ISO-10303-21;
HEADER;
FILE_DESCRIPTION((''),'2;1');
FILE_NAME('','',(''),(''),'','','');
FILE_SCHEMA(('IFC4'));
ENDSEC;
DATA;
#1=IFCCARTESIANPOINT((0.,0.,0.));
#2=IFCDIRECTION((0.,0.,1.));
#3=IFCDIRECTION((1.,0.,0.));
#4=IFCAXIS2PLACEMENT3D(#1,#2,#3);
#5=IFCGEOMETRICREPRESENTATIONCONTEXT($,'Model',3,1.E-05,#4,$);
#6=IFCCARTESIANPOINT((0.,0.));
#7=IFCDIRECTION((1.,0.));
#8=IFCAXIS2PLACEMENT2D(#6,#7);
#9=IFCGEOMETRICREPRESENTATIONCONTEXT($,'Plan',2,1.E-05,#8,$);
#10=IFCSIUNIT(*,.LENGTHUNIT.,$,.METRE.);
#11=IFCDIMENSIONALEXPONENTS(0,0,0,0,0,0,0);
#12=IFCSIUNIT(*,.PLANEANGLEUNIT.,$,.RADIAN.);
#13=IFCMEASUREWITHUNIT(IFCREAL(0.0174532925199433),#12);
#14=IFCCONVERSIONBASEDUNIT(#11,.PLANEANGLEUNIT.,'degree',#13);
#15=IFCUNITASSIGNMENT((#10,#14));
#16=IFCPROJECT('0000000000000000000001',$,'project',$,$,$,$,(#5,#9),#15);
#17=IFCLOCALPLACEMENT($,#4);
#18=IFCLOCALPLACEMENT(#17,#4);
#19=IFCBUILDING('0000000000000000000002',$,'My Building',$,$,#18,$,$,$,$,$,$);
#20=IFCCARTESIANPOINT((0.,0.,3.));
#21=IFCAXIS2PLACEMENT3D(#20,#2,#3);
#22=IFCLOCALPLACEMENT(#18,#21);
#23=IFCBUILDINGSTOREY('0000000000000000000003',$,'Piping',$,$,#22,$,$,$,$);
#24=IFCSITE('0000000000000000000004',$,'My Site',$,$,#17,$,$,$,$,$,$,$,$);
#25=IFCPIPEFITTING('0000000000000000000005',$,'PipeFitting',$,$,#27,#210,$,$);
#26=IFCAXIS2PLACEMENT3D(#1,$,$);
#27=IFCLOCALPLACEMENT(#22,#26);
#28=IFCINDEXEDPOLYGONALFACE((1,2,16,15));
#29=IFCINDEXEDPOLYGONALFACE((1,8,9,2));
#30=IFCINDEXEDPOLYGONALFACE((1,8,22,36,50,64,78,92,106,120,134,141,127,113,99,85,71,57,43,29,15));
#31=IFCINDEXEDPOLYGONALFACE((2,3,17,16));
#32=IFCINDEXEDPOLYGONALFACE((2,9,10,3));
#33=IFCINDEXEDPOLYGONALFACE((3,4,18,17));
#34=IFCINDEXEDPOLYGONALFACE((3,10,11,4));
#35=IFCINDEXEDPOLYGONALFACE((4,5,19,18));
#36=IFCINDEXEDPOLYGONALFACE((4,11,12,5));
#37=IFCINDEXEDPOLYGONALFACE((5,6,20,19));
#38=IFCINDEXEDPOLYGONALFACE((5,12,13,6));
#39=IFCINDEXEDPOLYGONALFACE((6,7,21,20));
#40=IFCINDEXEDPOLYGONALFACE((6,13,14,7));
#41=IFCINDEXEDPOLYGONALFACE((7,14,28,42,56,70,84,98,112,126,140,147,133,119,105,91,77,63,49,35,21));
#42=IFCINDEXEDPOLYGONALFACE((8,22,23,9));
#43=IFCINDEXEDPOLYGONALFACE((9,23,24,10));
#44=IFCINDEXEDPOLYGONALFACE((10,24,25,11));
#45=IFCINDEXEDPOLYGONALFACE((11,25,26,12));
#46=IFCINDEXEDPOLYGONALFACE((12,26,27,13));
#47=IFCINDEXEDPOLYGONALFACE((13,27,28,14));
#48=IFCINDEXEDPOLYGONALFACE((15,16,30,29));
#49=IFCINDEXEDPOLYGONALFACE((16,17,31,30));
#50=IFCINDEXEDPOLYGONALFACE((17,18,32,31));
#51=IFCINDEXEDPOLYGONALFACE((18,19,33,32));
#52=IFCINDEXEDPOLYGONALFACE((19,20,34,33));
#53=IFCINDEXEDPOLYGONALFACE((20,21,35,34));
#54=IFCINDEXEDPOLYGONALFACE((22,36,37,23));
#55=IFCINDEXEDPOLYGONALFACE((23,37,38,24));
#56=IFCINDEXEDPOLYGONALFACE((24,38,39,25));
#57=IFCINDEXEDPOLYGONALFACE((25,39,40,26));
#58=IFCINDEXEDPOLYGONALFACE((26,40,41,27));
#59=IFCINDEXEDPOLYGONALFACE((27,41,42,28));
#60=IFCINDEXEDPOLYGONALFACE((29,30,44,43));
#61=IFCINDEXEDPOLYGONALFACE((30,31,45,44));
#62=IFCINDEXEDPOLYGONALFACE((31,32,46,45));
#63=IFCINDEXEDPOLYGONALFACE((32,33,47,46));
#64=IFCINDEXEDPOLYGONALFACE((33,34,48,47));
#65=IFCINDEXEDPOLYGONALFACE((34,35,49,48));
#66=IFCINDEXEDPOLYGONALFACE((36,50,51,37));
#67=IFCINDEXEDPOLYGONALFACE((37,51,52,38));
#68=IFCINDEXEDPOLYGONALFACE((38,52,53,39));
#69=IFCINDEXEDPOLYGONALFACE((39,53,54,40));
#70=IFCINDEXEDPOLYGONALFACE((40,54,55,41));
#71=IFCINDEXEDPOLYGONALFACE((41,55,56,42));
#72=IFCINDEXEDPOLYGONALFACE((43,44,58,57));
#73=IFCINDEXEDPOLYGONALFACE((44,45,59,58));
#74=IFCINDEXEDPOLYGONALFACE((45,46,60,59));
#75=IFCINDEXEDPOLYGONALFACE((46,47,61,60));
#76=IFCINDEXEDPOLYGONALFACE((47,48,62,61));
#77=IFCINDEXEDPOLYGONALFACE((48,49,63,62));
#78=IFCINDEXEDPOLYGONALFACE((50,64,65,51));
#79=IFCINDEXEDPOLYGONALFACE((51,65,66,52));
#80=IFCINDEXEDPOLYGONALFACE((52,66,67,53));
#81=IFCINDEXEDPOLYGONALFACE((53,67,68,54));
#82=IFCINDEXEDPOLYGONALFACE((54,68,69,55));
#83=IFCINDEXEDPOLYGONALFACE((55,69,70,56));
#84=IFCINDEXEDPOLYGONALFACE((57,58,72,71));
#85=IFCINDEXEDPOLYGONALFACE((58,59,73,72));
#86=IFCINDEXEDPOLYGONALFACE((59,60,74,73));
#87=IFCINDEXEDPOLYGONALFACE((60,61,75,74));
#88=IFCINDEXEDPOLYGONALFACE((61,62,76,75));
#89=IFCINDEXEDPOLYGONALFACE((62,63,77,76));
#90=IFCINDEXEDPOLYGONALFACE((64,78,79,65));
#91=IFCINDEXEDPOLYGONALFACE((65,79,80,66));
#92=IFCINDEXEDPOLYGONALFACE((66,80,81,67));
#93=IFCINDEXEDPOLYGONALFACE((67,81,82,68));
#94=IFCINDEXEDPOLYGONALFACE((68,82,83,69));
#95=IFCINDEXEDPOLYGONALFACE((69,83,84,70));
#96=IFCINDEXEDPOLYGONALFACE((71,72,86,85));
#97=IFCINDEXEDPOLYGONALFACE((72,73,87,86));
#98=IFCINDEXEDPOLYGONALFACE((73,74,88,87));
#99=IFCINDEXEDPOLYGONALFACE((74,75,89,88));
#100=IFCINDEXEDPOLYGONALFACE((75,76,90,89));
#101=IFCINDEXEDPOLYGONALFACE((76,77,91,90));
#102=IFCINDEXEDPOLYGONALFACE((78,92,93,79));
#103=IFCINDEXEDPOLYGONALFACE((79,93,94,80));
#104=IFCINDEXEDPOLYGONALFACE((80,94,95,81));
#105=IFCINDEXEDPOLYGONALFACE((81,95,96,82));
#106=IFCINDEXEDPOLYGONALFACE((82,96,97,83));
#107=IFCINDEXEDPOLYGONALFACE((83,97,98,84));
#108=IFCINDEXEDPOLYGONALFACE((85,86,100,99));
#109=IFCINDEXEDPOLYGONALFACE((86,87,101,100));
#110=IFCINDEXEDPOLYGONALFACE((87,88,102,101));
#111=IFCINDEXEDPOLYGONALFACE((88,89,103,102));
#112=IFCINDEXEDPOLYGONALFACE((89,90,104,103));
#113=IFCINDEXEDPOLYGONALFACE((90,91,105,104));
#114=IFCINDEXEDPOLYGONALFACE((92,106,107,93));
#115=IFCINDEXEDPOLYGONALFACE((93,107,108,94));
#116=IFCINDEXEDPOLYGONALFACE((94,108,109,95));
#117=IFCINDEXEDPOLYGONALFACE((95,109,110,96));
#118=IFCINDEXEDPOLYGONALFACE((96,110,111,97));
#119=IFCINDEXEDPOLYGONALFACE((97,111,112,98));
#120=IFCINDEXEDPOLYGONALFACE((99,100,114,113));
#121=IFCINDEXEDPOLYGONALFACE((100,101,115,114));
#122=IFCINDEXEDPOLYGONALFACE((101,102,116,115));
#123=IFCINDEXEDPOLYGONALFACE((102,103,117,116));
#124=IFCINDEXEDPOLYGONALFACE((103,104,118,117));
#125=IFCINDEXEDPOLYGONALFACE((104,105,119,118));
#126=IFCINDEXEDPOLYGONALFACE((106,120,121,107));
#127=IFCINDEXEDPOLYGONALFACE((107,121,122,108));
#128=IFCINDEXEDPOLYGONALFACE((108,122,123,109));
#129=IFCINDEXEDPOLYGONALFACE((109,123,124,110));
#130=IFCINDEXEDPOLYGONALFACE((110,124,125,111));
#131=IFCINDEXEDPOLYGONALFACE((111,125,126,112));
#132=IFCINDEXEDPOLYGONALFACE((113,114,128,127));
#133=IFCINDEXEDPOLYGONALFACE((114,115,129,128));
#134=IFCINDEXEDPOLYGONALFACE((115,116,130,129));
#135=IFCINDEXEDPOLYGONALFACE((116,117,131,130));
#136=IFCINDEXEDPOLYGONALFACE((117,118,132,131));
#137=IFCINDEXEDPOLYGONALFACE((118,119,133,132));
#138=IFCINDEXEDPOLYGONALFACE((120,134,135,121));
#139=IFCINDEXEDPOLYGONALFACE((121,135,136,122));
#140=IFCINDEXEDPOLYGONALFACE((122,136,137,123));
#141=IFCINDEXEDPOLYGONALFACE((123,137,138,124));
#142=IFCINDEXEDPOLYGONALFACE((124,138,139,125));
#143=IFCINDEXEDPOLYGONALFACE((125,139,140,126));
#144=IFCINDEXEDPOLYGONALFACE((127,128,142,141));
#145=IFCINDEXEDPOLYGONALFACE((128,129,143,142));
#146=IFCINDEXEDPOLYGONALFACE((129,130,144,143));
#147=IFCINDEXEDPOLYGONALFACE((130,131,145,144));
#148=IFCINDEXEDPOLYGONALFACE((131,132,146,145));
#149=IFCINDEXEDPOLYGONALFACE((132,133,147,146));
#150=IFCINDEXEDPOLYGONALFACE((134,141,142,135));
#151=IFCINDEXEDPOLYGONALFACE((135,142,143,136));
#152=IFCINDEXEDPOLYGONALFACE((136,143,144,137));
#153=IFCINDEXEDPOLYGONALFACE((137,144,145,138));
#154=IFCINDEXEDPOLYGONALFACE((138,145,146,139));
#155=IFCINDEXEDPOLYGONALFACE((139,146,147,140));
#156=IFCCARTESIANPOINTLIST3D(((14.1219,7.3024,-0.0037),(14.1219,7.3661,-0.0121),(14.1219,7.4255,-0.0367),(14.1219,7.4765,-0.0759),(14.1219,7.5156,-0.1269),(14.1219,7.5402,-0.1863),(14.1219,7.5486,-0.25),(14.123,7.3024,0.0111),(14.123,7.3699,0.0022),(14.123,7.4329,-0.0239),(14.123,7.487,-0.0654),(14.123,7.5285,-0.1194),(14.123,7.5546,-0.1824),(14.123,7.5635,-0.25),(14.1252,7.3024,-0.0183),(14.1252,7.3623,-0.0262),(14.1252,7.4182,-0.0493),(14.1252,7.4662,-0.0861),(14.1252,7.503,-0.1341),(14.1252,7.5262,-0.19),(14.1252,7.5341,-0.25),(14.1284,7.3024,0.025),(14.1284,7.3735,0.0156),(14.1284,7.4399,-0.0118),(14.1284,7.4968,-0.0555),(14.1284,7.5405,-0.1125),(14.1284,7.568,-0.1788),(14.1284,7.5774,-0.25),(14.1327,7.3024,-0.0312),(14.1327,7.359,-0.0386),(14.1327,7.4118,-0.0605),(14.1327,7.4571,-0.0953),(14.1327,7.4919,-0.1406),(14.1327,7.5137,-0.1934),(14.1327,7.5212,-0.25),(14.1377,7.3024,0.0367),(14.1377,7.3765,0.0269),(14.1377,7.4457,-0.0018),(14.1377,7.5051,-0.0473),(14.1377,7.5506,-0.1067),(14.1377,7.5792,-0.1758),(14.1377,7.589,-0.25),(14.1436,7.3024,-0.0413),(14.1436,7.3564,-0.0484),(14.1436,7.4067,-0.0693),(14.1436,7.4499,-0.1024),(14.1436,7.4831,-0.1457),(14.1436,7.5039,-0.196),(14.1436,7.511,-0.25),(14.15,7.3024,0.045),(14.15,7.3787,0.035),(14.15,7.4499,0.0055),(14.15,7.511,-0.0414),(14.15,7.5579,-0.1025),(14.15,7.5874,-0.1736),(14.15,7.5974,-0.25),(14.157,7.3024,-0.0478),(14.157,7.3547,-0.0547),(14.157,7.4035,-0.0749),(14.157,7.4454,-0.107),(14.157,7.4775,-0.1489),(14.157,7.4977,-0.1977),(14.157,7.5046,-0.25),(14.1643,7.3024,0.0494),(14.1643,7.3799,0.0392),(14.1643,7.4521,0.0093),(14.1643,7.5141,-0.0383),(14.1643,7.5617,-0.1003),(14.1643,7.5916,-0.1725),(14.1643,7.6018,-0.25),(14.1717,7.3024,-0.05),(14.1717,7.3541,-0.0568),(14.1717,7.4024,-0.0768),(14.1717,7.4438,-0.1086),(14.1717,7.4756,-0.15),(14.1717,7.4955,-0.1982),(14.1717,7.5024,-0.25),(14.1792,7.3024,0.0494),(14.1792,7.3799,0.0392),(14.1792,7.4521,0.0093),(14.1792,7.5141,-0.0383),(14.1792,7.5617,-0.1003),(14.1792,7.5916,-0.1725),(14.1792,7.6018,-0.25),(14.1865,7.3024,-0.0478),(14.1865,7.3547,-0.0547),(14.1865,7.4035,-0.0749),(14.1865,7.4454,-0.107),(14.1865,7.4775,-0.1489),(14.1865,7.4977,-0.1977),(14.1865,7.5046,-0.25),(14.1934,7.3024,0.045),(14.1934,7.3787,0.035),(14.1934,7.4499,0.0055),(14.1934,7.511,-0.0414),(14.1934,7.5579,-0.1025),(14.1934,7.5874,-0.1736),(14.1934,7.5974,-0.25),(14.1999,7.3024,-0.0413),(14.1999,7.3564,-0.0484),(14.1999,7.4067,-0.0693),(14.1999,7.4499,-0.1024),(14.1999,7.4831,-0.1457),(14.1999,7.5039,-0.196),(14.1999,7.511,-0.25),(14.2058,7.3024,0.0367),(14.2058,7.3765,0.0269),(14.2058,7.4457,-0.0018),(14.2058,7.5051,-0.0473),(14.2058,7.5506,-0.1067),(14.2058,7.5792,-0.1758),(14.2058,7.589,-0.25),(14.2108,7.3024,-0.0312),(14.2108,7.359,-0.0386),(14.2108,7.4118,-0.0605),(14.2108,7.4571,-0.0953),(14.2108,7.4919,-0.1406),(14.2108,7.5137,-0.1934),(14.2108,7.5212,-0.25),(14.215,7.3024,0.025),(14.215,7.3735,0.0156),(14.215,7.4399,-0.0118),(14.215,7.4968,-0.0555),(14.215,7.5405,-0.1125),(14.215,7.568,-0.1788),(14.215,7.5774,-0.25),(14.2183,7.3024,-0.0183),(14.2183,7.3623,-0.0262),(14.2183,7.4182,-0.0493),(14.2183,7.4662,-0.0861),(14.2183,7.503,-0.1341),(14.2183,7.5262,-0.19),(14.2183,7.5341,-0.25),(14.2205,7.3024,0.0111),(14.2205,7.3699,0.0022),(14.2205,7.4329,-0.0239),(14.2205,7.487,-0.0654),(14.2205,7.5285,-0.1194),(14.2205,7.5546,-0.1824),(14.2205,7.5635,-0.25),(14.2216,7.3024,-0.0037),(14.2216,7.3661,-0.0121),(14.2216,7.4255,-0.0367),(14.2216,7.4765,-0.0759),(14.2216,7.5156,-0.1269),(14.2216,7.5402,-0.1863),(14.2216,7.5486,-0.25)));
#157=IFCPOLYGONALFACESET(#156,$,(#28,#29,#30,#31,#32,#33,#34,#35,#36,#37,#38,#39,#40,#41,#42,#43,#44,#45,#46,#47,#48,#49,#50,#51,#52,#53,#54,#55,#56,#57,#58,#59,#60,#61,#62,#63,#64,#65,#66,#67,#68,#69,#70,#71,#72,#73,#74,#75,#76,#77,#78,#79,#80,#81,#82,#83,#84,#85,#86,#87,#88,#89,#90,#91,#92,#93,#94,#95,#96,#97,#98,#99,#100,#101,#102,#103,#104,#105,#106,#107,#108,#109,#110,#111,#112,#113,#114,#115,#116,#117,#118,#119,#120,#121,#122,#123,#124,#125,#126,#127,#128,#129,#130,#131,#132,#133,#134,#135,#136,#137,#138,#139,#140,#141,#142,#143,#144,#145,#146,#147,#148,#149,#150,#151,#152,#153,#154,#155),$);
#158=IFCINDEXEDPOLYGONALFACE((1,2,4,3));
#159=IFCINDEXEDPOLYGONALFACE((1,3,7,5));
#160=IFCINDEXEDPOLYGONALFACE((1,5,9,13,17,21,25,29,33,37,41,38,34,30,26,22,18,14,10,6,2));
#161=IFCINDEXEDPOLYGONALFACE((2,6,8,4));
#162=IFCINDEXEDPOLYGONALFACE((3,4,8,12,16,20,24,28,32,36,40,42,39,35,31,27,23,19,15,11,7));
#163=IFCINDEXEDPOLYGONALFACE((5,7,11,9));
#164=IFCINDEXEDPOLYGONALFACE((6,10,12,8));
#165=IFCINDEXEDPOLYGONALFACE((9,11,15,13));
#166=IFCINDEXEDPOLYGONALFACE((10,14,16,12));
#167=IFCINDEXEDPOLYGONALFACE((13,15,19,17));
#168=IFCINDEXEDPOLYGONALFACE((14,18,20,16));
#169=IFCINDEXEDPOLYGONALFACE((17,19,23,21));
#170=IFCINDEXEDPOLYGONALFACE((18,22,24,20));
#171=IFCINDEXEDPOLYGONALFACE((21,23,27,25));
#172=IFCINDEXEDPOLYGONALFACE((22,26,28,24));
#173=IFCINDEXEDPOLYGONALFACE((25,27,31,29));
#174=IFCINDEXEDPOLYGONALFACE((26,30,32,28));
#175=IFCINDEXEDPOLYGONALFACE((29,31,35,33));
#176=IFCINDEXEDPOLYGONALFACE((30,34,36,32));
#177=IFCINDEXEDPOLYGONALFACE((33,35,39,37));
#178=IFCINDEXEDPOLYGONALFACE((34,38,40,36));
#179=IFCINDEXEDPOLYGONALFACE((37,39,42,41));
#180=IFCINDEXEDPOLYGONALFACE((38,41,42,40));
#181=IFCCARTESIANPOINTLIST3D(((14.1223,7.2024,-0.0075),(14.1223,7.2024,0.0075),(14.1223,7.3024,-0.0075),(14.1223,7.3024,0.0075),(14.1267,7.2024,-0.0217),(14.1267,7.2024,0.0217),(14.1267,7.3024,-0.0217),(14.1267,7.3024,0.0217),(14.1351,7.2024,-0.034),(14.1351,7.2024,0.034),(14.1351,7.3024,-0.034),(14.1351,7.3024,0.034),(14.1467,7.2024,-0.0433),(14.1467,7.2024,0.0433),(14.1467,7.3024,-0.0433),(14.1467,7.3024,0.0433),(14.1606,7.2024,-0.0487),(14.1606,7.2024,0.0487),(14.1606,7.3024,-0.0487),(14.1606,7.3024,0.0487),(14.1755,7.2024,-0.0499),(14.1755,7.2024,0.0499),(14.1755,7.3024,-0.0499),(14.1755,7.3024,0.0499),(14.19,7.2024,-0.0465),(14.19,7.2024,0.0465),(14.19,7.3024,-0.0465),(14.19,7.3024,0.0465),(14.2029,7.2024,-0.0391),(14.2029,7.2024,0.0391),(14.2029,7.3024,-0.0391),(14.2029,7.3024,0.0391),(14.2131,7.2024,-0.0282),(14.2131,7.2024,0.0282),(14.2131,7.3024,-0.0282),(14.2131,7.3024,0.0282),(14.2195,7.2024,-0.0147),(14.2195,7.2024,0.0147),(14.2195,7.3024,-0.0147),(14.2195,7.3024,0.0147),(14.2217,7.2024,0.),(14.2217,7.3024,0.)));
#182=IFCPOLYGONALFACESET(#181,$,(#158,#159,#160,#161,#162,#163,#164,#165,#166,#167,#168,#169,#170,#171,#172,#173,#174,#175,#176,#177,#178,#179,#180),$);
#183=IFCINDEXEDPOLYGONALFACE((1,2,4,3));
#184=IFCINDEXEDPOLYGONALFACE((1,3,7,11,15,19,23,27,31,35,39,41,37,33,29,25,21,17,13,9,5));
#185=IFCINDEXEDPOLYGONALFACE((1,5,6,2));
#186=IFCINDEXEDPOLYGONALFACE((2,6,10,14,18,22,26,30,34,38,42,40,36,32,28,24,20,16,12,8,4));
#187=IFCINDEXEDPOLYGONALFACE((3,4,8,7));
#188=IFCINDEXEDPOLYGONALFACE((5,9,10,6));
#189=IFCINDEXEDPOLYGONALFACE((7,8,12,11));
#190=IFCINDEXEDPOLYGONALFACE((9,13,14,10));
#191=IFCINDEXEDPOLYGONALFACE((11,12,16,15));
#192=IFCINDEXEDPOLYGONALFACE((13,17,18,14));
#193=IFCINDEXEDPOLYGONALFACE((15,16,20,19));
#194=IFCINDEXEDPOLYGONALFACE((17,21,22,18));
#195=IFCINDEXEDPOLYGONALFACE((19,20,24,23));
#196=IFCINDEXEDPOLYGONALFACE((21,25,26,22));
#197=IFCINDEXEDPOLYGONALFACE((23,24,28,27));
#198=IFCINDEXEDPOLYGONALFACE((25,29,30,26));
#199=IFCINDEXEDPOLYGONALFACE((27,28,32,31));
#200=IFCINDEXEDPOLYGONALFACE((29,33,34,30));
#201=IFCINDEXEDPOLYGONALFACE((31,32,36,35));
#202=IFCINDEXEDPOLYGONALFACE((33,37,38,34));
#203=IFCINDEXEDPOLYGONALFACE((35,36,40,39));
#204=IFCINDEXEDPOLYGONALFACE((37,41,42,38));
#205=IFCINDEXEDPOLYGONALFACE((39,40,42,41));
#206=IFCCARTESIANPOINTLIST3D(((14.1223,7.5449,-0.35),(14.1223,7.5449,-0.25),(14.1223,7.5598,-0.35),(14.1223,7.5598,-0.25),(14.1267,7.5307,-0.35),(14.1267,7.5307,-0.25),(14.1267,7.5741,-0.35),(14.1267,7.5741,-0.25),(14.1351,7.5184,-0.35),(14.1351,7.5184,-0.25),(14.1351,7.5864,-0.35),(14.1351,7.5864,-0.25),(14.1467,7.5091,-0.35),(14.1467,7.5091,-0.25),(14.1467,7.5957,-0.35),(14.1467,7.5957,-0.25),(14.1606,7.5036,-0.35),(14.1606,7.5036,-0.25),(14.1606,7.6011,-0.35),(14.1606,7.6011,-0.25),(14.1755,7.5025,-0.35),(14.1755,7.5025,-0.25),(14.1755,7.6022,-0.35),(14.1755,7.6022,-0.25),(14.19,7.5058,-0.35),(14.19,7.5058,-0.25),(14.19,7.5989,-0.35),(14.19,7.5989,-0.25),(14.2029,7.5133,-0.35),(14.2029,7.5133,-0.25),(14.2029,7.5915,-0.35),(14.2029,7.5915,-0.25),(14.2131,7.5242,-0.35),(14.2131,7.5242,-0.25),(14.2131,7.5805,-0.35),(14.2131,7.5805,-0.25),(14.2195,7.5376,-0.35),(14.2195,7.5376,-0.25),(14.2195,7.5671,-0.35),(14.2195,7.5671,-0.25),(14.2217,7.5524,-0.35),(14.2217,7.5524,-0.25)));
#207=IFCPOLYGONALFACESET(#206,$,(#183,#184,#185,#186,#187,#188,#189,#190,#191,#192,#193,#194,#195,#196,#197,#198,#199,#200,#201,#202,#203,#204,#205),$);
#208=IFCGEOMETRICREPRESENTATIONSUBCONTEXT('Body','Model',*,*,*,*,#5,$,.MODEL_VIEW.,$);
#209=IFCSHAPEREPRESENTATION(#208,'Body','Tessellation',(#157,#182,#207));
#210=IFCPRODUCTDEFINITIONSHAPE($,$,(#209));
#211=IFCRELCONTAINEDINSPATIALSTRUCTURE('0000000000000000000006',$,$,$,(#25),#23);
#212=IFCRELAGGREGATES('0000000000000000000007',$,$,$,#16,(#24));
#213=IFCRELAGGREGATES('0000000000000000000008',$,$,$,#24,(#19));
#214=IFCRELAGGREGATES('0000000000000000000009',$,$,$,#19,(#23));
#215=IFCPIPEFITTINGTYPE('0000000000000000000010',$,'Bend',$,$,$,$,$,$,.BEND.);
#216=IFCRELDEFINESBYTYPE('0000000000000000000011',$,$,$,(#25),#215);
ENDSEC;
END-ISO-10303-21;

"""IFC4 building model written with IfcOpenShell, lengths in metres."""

from ifc_helpers import new_model, entity, si_unit, converted_unit, frame, origin_with_axes, origin_2d_with_axis, place, context, subcontext, project, spatial, circle, extrude, source, transform, mapped, type_object, type_shapes, element, save


model = new_model("IFC4")

# Units and contexts
model_context = context("Model", 3, precision=1e-05, world=origin_with_axes())
plan_context = context("Plan", 2, precision=1e-05, world=origin_2d_with_axis())
body_context = subcontext(model_context, "Body", "Model", "MODEL_VIEW")
ifc_project = project(units=[si_unit("LENGTHUNIT", "METRE"), converted_unit("PLANEANGLEUNIT", "degree", entity("IfcReal", 0.0174532925199433), si_unit("PLANEANGLEUNIT", "RADIAN"), dimensions=[0, 0, 0, 0, 0, 0, 0])], contexts=[model_context, plan_context])

# Site, building, storey
site_placement = place(None, origin_with_axes())
site = spatial("IfcSite", under=ifc_project, at=site_placement, Name="My Site")
building_placement = place(site_placement, origin_with_axes())
building = spatial("IfcBuilding", under=site, at=building_placement, Name="My Building")
storey_placement = place(building_placement, frame((0.0, 0.0, 3.0), z_axis=(0.0, 0.0, 1.0), x_axis=(1.0, 0.0, 0.0)))
storey = spatial("IfcBuildingStorey", under=building, at=storey_placement, Name="Piping")

# Pipe fitting
pipe_fitting_type_1 = type_object("IfcPipeFittingType", Name="Bend", PredefinedType="BEND")
shared_shape = source(origin_with_axes(), body_context, "Body", "SolidModel", [
    entity("IfcSweptDiskSolid", entity("IfcIndexedPolyCurve", entity("IfcCartesianPointList3D", [[0.0, 0.0, -0.1], [0.0, -0.0732, -0.2768], [0.0, -0.25, -0.35]]), [entity("IfcArcIndex", [1, 2, 3])]), 0.05),
    extrude(circle(Radius=0.05), origin_with_axes(), (0.0, 0.0, -1.0), 0.1),
    extrude(circle(Radius=0.05), frame((0.0, -0.25, -0.35), z_axis=(0.0, -1.0, 0.0), x_axis=(1.0, 0.0, 0.0)), (0.0, 0.0, 1.0), 0.1),
])
type_shapes(pipe_fitting_type_1, [shared_shape])
for number, where, z_axis, x_axis, name in (
    (1, (14.1717, 7.2024, 0.0), (0.0, -1.0, 0.0), (1.0, 0.0, 0.0), "PipeFitting"),
):
    element("IfcPipeFitting", number, at=place(storey_placement, frame(where, z_axis=z_axis, x_axis=x_axis)), inside=storey, type_object=pipe_fitting_type_1, Name=name, context=body_context, shape_type="MappedRepresentation", body=[
        mapped(shared_shape, transform((0.0, 0.0, 0.0), x_axis=(1.0, 0.0, 0.0), y_axis=(0.0, 1.0, 0.0), z_axis=(0.0, 0.0, 1.0), scale=1.0)),
    ])

save(model, "model.ifc")
